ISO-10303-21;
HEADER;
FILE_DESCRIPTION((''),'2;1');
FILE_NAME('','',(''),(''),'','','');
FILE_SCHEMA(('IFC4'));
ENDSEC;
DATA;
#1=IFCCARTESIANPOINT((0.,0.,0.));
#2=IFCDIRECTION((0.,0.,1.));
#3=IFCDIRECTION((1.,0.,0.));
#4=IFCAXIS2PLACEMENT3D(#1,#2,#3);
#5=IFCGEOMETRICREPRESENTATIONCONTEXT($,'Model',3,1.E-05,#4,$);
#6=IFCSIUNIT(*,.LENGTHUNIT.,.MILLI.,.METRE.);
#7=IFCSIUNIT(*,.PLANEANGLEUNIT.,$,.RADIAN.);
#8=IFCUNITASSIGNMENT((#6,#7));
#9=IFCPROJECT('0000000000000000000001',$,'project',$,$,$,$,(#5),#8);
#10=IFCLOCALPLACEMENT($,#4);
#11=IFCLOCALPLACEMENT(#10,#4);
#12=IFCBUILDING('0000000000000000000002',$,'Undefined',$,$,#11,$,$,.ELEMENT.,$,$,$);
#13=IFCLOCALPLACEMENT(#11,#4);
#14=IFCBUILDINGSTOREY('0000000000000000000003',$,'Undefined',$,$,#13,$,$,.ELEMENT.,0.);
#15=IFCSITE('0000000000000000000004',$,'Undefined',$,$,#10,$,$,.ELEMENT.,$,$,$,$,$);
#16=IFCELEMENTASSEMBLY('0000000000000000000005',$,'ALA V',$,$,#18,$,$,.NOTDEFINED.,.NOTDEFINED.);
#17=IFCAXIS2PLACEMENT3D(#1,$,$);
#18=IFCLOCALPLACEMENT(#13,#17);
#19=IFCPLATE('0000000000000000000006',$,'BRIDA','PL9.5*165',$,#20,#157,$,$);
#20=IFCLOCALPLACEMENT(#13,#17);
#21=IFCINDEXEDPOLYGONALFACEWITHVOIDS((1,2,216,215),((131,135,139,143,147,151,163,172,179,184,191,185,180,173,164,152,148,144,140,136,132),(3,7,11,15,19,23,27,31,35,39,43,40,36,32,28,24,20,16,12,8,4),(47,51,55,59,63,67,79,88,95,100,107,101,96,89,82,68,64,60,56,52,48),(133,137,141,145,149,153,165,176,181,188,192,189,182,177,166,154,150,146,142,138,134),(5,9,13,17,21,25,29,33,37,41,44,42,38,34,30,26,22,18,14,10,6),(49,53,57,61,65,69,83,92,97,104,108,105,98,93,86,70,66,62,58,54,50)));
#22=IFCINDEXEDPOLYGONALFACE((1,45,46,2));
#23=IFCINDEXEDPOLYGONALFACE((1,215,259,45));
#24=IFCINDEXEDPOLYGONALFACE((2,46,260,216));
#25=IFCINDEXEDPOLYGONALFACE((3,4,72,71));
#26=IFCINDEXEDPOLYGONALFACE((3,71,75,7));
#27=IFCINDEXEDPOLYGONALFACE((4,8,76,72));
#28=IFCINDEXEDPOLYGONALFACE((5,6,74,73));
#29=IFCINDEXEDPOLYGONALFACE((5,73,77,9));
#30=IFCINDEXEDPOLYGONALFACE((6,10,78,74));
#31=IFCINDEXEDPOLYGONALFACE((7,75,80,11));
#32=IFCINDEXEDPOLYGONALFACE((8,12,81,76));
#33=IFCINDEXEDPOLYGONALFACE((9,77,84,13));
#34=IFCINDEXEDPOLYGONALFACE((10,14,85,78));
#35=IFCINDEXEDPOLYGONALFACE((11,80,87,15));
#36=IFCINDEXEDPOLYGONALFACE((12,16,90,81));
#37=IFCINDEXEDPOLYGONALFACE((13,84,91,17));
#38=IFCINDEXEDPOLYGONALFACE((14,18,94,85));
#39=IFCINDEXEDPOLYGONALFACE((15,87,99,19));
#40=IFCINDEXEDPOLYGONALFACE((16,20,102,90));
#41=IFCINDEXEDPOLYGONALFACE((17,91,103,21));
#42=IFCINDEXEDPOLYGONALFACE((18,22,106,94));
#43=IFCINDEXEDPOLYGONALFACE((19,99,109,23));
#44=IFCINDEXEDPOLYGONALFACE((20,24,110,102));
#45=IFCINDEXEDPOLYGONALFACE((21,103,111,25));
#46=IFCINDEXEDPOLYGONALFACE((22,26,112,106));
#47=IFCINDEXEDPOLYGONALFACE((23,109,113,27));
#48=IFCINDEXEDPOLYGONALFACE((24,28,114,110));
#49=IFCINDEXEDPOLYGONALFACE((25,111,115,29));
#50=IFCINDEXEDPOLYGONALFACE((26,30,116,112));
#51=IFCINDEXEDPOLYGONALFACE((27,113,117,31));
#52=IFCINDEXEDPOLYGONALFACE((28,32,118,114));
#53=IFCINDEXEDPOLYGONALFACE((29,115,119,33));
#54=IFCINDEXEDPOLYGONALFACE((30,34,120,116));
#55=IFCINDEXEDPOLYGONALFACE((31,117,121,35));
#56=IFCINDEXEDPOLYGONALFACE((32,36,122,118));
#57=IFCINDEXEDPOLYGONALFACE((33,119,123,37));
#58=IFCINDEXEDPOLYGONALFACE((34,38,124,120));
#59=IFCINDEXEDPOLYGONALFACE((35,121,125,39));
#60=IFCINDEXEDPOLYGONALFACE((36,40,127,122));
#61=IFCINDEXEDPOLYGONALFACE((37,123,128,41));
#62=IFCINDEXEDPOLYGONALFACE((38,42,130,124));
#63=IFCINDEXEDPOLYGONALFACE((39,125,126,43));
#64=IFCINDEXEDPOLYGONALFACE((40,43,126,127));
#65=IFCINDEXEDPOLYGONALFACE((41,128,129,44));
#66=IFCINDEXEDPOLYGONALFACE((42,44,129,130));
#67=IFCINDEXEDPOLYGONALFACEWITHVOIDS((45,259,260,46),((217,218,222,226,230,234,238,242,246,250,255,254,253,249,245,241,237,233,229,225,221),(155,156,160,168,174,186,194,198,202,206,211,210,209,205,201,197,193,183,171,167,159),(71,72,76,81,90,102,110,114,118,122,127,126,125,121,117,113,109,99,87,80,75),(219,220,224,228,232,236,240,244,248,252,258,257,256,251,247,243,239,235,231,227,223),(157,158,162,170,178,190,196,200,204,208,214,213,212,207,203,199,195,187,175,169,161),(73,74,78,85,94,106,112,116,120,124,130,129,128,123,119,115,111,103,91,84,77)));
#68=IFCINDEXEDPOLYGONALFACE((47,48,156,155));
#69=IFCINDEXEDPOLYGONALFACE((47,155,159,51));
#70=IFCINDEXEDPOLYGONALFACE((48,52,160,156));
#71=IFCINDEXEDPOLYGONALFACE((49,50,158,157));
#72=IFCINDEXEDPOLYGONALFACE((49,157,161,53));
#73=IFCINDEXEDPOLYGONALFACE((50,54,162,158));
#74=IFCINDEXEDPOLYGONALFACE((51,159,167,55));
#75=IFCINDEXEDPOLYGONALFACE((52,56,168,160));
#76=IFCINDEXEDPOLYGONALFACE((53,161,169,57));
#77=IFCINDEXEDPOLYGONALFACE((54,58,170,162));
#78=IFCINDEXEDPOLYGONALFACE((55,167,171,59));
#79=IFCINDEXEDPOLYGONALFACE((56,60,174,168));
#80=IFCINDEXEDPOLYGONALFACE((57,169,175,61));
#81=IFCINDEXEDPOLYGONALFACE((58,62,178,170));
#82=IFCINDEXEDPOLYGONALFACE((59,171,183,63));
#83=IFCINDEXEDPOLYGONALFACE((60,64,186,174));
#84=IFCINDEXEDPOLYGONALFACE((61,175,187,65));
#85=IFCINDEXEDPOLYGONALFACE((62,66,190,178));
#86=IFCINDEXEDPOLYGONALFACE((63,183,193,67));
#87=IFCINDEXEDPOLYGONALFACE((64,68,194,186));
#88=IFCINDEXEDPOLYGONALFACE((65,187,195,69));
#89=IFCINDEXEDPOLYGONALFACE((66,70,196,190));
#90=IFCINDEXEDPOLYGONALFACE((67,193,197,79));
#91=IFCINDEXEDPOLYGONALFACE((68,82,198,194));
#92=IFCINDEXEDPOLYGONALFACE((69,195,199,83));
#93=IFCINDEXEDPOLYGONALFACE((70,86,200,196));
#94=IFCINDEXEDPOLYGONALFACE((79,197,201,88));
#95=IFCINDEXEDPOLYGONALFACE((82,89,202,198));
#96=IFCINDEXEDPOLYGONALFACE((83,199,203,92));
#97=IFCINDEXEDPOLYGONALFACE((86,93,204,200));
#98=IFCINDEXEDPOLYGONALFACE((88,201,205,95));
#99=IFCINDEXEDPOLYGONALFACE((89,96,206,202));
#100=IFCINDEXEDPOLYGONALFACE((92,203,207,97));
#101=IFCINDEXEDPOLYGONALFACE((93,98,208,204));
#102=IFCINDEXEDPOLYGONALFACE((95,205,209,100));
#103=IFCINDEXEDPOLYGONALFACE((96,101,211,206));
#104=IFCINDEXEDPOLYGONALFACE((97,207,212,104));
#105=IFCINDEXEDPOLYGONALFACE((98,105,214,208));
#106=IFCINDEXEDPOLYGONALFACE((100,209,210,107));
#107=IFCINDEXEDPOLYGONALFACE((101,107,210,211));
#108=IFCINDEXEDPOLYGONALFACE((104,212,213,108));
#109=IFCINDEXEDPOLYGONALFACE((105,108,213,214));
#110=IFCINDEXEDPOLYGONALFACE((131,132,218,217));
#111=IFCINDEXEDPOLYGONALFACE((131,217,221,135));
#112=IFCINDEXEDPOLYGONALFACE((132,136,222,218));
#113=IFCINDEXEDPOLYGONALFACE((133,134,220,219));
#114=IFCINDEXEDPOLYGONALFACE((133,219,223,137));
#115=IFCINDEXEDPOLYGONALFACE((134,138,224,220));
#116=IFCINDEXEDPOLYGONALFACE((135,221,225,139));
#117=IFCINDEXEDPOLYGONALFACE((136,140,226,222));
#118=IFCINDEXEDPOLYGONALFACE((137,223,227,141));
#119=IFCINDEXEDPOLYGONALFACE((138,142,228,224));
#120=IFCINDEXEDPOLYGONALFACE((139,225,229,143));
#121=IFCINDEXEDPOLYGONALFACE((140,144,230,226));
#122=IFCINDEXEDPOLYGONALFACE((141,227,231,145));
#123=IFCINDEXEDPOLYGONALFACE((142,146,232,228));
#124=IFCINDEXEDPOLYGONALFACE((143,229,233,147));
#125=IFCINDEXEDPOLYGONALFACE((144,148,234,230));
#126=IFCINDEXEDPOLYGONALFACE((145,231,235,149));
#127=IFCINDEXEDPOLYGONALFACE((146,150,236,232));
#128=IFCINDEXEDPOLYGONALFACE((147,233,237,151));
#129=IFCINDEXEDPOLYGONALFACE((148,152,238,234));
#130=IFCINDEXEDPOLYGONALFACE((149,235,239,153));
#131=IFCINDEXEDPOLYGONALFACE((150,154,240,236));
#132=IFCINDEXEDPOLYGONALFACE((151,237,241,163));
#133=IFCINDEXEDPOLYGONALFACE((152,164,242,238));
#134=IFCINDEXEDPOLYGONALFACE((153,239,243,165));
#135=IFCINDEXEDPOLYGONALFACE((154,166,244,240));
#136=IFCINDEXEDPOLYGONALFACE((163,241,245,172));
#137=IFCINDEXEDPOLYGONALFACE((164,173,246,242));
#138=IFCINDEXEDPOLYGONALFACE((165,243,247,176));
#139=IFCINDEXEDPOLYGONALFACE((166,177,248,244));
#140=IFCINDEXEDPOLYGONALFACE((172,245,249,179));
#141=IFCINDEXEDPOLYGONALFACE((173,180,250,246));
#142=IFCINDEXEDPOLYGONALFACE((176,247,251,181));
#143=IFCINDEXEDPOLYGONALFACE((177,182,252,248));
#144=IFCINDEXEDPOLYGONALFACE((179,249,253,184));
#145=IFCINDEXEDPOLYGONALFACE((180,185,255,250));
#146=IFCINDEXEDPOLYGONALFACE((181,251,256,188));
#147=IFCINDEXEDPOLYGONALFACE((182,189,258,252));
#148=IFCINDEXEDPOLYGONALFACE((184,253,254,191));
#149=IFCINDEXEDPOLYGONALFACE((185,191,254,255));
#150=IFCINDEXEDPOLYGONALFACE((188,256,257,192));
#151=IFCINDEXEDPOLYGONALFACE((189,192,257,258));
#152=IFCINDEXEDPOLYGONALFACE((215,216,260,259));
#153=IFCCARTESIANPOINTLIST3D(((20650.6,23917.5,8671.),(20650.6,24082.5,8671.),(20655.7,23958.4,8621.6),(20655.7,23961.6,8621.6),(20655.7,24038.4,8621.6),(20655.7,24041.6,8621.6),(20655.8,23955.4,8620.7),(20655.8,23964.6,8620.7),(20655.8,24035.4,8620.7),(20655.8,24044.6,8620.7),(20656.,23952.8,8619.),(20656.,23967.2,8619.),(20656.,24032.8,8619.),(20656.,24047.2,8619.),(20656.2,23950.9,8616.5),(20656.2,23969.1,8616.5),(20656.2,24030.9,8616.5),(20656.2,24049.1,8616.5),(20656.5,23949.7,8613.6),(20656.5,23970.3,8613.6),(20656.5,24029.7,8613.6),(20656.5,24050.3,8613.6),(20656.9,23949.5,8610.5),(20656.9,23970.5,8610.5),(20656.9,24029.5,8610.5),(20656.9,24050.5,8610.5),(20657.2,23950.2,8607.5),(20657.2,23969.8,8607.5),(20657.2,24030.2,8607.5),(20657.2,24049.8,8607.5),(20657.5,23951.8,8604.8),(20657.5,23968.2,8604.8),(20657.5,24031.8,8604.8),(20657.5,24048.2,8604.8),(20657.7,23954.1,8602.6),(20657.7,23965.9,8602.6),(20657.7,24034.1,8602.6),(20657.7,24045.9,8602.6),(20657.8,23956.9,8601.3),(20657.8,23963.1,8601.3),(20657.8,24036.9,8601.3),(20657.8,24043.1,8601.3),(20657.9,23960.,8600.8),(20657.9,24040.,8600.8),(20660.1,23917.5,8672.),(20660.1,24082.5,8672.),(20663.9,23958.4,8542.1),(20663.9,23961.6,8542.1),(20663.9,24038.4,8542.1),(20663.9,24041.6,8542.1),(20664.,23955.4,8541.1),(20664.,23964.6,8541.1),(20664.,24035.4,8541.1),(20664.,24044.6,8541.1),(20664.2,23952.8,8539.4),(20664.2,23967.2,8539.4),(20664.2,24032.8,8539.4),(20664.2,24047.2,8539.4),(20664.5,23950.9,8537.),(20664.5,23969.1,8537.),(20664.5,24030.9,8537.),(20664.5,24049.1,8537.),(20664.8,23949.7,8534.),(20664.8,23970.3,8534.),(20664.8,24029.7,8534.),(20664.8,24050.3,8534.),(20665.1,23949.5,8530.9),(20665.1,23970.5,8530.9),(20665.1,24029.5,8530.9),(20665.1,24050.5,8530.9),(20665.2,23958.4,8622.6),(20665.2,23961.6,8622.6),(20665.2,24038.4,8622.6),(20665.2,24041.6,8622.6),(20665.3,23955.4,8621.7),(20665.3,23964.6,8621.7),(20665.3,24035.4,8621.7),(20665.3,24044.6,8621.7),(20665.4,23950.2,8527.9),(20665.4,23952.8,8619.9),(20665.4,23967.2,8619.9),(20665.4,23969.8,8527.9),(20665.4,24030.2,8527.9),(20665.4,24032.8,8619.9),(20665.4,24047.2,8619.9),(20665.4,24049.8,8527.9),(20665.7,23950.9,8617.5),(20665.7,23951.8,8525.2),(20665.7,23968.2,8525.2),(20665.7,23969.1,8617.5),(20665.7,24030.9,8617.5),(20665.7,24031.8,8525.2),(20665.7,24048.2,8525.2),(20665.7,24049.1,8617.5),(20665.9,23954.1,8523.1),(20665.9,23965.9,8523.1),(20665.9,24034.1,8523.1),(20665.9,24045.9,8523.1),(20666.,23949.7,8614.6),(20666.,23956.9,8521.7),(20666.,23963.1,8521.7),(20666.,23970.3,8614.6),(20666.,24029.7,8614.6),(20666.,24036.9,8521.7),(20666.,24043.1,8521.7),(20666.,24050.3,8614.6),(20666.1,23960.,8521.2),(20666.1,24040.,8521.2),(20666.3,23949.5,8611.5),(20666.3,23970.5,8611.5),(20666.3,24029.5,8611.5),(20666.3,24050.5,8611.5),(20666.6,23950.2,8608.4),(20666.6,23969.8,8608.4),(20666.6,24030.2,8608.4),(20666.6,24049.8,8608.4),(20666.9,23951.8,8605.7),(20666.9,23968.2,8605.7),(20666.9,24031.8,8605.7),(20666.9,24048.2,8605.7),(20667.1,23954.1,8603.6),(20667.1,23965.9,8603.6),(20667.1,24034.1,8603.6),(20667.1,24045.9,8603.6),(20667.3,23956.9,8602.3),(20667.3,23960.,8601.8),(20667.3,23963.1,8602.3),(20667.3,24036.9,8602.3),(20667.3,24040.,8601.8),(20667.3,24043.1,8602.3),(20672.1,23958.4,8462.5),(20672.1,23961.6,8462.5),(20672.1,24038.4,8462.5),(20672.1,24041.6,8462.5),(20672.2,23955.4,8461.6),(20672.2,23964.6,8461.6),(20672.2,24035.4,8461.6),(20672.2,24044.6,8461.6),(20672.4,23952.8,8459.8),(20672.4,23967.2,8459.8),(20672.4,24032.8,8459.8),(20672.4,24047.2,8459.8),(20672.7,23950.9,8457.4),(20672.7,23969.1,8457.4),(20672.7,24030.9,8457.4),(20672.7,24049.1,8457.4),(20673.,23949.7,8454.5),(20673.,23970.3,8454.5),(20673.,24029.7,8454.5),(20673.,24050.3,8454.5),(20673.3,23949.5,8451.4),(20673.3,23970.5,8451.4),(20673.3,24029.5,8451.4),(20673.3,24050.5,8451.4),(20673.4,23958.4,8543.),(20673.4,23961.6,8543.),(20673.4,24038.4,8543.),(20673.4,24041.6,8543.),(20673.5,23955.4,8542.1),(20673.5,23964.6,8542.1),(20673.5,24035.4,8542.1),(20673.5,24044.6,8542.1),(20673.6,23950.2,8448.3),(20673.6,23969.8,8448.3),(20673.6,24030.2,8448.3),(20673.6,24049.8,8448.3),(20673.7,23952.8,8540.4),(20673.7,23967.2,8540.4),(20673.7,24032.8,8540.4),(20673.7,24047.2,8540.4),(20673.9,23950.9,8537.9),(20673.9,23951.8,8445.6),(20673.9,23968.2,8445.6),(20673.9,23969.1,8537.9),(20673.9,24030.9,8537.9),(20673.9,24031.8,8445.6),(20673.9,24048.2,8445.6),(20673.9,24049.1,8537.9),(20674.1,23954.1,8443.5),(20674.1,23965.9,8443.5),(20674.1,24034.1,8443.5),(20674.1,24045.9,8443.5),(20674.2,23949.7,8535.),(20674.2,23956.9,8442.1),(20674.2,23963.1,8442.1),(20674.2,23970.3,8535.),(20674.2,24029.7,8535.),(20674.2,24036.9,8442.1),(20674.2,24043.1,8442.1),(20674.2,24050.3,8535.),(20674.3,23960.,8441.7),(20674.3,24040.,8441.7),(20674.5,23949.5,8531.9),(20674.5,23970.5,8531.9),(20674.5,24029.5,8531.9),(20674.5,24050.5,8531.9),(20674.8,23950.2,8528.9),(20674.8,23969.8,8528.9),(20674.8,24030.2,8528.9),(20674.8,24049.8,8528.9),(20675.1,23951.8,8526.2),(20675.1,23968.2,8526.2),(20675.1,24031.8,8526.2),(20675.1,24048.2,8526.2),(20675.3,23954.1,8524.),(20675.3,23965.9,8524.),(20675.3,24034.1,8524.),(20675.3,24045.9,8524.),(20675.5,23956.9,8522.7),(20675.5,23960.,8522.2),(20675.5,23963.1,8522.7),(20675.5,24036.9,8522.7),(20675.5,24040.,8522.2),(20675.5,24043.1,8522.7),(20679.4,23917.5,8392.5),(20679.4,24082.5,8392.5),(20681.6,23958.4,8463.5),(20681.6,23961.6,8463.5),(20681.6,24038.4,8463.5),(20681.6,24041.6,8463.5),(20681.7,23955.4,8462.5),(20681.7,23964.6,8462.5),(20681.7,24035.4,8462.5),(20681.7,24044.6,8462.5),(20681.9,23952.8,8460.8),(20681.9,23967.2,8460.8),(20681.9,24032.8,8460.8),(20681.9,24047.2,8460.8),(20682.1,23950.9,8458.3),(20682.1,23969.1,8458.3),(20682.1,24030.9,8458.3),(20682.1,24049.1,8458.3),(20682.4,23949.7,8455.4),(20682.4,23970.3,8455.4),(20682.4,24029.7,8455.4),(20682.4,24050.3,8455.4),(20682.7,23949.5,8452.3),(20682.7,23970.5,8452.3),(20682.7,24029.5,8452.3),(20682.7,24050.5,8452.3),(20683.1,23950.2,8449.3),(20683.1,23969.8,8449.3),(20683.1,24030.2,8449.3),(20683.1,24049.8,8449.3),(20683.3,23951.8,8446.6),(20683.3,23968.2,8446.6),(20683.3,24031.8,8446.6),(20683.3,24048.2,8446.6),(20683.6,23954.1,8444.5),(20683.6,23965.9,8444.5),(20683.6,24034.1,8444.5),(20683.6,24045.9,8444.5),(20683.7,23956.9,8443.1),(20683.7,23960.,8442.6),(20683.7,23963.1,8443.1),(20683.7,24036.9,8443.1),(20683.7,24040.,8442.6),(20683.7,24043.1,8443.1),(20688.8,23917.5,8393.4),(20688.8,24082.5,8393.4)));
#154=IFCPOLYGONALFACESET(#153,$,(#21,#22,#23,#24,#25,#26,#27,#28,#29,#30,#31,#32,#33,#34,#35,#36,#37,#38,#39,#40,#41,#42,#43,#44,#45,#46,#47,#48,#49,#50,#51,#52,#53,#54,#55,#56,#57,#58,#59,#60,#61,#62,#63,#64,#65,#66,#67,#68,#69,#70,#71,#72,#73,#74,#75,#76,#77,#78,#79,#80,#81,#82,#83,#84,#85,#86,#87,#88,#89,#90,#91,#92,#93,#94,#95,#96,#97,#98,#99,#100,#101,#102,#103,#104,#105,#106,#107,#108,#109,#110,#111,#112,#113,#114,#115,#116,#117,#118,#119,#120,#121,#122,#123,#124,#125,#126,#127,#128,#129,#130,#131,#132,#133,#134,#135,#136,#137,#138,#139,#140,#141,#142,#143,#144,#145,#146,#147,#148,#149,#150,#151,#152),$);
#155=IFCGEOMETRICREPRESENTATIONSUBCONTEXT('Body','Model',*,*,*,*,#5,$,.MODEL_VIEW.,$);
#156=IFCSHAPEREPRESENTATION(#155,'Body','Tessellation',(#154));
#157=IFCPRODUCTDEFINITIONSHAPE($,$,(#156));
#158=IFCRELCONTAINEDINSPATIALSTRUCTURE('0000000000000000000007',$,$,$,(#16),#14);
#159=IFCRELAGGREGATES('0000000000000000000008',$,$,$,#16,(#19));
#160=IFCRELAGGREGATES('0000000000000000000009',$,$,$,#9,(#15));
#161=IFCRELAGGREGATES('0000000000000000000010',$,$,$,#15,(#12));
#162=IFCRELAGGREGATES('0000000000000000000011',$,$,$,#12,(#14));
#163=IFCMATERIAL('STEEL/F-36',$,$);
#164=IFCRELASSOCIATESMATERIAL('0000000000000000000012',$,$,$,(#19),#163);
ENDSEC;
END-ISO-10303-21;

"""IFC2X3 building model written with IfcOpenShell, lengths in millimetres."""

from ifc_helpers import new_model, si_unit, frame, origin_with_axes, origin_2d_with_axis, place, context, subcontext, project, spatial, polyline, circle, outline, extrude, source, transform, mapped, material, element, aggregate, save


model = new_model("IFC2X3")

# Units and contexts
model_context = context("Model", 3, precision=1e-05, world=origin_with_axes())
body_context = subcontext(model_context, "Body", "Model", "MODEL_VIEW")
ifc_project = project(units=[si_unit("LENGTHUNIT", "METRE", prefix="MILLI"), si_unit("PLANEANGLEUNIT", "RADIAN")], contexts=[model_context])

# Site, building, storey
site_placement = place(None, origin_with_axes())
site = spatial("IfcSite", under=ifc_project, at=site_placement, Name="Undefined", CompositionType="ELEMENT")
building_placement = place(site_placement, origin_with_axes())
building = spatial("IfcBuilding", under=site, at=building_placement, Name="Undefined", CompositionType="ELEMENT")
storey_placement = place(building_placement, origin_with_axes())
storey = spatial("IfcBuildingStorey", under=building, at=storey_placement, Name="Undefined", CompositionType="ELEMENT", Elevation=0.0)

# Shared definitions
ifc_material_1 = material(Name="STEEL/F-36")

# Element assembly, plate, opening
assembly_1_placement = place(storey_placement, origin_with_axes())
assembly_1 = element("IfcElementAssembly", 1, at=assembly_1_placement, inside=storey, Name="ALA V", AssemblyPlace="NOTDEFINED", PredefinedType="NOTDEFINED")
plate_1_placement = place(assembly_1_placement, frame((20655.3, 23917.5, 8671.5), z_axis=(0.994715, 0.0, 0.102675), x_axis=(0.102675, 0.0, -0.994715)))
plate_1 = element("IfcPlate", 2, at=plate_1_placement, material=ifc_material_1, Name="BRIDA", Description="PL9.5*165", context=body_context, shape_type="SweptSolid", body=[
    extrude(outline(polyline([(0.0, 0.0), (280.0, 0.0), (280.0, 165.0), (0.0, 165.0), (0.0, 0.0)])), frame((0.0, 0.0, -4.8), z_axis=(0.0, 0.0, 1.0), x_axis=(1.0, 0.0, 0.0)), (0.0, 0.0, 1.0), 9.5),
])
shared_shape_1 = source(origin_with_axes(), body_context, "Body", "SweptSolid", [
    extrude(circle(Radius=10.5, at=origin_2d_with_axis()), frame((0.0, -0.1, 0.0), z_axis=(0.0, 1.0, 0.0), x_axis=(1.0, 0.0, 0.0)), (0.0, 0.0, 1.0), 9.7),
])
opening_1_placement = place(assembly_1_placement, frame((20666.2, 24000.0, 8612.3), z_axis=(0.0, 1.0, 0.0), x_axis=(0.102675, 0.0, -0.994715)))
element("IfcOpeningElement", 3, at=opening_1_placement, cuts=plate_1, ObjectType="Opening", context=body_context, shape_type="MappedRepresentation", body=[
    mapped(shared_shape_1, transform((0.0, 0.0, -40.0))),
    mapped(shared_shape_1, transform((80.0, 0.0, -40.0))),
    mapped(shared_shape_1, transform((160.0, 0.0, -40.0))),
    mapped(shared_shape_1, transform((0.0, 0.0, 40.0))),
    mapped(shared_shape_1, transform((80.0, 0.0, 40.0))),
    mapped(shared_shape_1, transform((160.0, 0.0, 40.0))),
])
aggregate(assembly_1, [plate_1])

save(model, "model.ifc")
